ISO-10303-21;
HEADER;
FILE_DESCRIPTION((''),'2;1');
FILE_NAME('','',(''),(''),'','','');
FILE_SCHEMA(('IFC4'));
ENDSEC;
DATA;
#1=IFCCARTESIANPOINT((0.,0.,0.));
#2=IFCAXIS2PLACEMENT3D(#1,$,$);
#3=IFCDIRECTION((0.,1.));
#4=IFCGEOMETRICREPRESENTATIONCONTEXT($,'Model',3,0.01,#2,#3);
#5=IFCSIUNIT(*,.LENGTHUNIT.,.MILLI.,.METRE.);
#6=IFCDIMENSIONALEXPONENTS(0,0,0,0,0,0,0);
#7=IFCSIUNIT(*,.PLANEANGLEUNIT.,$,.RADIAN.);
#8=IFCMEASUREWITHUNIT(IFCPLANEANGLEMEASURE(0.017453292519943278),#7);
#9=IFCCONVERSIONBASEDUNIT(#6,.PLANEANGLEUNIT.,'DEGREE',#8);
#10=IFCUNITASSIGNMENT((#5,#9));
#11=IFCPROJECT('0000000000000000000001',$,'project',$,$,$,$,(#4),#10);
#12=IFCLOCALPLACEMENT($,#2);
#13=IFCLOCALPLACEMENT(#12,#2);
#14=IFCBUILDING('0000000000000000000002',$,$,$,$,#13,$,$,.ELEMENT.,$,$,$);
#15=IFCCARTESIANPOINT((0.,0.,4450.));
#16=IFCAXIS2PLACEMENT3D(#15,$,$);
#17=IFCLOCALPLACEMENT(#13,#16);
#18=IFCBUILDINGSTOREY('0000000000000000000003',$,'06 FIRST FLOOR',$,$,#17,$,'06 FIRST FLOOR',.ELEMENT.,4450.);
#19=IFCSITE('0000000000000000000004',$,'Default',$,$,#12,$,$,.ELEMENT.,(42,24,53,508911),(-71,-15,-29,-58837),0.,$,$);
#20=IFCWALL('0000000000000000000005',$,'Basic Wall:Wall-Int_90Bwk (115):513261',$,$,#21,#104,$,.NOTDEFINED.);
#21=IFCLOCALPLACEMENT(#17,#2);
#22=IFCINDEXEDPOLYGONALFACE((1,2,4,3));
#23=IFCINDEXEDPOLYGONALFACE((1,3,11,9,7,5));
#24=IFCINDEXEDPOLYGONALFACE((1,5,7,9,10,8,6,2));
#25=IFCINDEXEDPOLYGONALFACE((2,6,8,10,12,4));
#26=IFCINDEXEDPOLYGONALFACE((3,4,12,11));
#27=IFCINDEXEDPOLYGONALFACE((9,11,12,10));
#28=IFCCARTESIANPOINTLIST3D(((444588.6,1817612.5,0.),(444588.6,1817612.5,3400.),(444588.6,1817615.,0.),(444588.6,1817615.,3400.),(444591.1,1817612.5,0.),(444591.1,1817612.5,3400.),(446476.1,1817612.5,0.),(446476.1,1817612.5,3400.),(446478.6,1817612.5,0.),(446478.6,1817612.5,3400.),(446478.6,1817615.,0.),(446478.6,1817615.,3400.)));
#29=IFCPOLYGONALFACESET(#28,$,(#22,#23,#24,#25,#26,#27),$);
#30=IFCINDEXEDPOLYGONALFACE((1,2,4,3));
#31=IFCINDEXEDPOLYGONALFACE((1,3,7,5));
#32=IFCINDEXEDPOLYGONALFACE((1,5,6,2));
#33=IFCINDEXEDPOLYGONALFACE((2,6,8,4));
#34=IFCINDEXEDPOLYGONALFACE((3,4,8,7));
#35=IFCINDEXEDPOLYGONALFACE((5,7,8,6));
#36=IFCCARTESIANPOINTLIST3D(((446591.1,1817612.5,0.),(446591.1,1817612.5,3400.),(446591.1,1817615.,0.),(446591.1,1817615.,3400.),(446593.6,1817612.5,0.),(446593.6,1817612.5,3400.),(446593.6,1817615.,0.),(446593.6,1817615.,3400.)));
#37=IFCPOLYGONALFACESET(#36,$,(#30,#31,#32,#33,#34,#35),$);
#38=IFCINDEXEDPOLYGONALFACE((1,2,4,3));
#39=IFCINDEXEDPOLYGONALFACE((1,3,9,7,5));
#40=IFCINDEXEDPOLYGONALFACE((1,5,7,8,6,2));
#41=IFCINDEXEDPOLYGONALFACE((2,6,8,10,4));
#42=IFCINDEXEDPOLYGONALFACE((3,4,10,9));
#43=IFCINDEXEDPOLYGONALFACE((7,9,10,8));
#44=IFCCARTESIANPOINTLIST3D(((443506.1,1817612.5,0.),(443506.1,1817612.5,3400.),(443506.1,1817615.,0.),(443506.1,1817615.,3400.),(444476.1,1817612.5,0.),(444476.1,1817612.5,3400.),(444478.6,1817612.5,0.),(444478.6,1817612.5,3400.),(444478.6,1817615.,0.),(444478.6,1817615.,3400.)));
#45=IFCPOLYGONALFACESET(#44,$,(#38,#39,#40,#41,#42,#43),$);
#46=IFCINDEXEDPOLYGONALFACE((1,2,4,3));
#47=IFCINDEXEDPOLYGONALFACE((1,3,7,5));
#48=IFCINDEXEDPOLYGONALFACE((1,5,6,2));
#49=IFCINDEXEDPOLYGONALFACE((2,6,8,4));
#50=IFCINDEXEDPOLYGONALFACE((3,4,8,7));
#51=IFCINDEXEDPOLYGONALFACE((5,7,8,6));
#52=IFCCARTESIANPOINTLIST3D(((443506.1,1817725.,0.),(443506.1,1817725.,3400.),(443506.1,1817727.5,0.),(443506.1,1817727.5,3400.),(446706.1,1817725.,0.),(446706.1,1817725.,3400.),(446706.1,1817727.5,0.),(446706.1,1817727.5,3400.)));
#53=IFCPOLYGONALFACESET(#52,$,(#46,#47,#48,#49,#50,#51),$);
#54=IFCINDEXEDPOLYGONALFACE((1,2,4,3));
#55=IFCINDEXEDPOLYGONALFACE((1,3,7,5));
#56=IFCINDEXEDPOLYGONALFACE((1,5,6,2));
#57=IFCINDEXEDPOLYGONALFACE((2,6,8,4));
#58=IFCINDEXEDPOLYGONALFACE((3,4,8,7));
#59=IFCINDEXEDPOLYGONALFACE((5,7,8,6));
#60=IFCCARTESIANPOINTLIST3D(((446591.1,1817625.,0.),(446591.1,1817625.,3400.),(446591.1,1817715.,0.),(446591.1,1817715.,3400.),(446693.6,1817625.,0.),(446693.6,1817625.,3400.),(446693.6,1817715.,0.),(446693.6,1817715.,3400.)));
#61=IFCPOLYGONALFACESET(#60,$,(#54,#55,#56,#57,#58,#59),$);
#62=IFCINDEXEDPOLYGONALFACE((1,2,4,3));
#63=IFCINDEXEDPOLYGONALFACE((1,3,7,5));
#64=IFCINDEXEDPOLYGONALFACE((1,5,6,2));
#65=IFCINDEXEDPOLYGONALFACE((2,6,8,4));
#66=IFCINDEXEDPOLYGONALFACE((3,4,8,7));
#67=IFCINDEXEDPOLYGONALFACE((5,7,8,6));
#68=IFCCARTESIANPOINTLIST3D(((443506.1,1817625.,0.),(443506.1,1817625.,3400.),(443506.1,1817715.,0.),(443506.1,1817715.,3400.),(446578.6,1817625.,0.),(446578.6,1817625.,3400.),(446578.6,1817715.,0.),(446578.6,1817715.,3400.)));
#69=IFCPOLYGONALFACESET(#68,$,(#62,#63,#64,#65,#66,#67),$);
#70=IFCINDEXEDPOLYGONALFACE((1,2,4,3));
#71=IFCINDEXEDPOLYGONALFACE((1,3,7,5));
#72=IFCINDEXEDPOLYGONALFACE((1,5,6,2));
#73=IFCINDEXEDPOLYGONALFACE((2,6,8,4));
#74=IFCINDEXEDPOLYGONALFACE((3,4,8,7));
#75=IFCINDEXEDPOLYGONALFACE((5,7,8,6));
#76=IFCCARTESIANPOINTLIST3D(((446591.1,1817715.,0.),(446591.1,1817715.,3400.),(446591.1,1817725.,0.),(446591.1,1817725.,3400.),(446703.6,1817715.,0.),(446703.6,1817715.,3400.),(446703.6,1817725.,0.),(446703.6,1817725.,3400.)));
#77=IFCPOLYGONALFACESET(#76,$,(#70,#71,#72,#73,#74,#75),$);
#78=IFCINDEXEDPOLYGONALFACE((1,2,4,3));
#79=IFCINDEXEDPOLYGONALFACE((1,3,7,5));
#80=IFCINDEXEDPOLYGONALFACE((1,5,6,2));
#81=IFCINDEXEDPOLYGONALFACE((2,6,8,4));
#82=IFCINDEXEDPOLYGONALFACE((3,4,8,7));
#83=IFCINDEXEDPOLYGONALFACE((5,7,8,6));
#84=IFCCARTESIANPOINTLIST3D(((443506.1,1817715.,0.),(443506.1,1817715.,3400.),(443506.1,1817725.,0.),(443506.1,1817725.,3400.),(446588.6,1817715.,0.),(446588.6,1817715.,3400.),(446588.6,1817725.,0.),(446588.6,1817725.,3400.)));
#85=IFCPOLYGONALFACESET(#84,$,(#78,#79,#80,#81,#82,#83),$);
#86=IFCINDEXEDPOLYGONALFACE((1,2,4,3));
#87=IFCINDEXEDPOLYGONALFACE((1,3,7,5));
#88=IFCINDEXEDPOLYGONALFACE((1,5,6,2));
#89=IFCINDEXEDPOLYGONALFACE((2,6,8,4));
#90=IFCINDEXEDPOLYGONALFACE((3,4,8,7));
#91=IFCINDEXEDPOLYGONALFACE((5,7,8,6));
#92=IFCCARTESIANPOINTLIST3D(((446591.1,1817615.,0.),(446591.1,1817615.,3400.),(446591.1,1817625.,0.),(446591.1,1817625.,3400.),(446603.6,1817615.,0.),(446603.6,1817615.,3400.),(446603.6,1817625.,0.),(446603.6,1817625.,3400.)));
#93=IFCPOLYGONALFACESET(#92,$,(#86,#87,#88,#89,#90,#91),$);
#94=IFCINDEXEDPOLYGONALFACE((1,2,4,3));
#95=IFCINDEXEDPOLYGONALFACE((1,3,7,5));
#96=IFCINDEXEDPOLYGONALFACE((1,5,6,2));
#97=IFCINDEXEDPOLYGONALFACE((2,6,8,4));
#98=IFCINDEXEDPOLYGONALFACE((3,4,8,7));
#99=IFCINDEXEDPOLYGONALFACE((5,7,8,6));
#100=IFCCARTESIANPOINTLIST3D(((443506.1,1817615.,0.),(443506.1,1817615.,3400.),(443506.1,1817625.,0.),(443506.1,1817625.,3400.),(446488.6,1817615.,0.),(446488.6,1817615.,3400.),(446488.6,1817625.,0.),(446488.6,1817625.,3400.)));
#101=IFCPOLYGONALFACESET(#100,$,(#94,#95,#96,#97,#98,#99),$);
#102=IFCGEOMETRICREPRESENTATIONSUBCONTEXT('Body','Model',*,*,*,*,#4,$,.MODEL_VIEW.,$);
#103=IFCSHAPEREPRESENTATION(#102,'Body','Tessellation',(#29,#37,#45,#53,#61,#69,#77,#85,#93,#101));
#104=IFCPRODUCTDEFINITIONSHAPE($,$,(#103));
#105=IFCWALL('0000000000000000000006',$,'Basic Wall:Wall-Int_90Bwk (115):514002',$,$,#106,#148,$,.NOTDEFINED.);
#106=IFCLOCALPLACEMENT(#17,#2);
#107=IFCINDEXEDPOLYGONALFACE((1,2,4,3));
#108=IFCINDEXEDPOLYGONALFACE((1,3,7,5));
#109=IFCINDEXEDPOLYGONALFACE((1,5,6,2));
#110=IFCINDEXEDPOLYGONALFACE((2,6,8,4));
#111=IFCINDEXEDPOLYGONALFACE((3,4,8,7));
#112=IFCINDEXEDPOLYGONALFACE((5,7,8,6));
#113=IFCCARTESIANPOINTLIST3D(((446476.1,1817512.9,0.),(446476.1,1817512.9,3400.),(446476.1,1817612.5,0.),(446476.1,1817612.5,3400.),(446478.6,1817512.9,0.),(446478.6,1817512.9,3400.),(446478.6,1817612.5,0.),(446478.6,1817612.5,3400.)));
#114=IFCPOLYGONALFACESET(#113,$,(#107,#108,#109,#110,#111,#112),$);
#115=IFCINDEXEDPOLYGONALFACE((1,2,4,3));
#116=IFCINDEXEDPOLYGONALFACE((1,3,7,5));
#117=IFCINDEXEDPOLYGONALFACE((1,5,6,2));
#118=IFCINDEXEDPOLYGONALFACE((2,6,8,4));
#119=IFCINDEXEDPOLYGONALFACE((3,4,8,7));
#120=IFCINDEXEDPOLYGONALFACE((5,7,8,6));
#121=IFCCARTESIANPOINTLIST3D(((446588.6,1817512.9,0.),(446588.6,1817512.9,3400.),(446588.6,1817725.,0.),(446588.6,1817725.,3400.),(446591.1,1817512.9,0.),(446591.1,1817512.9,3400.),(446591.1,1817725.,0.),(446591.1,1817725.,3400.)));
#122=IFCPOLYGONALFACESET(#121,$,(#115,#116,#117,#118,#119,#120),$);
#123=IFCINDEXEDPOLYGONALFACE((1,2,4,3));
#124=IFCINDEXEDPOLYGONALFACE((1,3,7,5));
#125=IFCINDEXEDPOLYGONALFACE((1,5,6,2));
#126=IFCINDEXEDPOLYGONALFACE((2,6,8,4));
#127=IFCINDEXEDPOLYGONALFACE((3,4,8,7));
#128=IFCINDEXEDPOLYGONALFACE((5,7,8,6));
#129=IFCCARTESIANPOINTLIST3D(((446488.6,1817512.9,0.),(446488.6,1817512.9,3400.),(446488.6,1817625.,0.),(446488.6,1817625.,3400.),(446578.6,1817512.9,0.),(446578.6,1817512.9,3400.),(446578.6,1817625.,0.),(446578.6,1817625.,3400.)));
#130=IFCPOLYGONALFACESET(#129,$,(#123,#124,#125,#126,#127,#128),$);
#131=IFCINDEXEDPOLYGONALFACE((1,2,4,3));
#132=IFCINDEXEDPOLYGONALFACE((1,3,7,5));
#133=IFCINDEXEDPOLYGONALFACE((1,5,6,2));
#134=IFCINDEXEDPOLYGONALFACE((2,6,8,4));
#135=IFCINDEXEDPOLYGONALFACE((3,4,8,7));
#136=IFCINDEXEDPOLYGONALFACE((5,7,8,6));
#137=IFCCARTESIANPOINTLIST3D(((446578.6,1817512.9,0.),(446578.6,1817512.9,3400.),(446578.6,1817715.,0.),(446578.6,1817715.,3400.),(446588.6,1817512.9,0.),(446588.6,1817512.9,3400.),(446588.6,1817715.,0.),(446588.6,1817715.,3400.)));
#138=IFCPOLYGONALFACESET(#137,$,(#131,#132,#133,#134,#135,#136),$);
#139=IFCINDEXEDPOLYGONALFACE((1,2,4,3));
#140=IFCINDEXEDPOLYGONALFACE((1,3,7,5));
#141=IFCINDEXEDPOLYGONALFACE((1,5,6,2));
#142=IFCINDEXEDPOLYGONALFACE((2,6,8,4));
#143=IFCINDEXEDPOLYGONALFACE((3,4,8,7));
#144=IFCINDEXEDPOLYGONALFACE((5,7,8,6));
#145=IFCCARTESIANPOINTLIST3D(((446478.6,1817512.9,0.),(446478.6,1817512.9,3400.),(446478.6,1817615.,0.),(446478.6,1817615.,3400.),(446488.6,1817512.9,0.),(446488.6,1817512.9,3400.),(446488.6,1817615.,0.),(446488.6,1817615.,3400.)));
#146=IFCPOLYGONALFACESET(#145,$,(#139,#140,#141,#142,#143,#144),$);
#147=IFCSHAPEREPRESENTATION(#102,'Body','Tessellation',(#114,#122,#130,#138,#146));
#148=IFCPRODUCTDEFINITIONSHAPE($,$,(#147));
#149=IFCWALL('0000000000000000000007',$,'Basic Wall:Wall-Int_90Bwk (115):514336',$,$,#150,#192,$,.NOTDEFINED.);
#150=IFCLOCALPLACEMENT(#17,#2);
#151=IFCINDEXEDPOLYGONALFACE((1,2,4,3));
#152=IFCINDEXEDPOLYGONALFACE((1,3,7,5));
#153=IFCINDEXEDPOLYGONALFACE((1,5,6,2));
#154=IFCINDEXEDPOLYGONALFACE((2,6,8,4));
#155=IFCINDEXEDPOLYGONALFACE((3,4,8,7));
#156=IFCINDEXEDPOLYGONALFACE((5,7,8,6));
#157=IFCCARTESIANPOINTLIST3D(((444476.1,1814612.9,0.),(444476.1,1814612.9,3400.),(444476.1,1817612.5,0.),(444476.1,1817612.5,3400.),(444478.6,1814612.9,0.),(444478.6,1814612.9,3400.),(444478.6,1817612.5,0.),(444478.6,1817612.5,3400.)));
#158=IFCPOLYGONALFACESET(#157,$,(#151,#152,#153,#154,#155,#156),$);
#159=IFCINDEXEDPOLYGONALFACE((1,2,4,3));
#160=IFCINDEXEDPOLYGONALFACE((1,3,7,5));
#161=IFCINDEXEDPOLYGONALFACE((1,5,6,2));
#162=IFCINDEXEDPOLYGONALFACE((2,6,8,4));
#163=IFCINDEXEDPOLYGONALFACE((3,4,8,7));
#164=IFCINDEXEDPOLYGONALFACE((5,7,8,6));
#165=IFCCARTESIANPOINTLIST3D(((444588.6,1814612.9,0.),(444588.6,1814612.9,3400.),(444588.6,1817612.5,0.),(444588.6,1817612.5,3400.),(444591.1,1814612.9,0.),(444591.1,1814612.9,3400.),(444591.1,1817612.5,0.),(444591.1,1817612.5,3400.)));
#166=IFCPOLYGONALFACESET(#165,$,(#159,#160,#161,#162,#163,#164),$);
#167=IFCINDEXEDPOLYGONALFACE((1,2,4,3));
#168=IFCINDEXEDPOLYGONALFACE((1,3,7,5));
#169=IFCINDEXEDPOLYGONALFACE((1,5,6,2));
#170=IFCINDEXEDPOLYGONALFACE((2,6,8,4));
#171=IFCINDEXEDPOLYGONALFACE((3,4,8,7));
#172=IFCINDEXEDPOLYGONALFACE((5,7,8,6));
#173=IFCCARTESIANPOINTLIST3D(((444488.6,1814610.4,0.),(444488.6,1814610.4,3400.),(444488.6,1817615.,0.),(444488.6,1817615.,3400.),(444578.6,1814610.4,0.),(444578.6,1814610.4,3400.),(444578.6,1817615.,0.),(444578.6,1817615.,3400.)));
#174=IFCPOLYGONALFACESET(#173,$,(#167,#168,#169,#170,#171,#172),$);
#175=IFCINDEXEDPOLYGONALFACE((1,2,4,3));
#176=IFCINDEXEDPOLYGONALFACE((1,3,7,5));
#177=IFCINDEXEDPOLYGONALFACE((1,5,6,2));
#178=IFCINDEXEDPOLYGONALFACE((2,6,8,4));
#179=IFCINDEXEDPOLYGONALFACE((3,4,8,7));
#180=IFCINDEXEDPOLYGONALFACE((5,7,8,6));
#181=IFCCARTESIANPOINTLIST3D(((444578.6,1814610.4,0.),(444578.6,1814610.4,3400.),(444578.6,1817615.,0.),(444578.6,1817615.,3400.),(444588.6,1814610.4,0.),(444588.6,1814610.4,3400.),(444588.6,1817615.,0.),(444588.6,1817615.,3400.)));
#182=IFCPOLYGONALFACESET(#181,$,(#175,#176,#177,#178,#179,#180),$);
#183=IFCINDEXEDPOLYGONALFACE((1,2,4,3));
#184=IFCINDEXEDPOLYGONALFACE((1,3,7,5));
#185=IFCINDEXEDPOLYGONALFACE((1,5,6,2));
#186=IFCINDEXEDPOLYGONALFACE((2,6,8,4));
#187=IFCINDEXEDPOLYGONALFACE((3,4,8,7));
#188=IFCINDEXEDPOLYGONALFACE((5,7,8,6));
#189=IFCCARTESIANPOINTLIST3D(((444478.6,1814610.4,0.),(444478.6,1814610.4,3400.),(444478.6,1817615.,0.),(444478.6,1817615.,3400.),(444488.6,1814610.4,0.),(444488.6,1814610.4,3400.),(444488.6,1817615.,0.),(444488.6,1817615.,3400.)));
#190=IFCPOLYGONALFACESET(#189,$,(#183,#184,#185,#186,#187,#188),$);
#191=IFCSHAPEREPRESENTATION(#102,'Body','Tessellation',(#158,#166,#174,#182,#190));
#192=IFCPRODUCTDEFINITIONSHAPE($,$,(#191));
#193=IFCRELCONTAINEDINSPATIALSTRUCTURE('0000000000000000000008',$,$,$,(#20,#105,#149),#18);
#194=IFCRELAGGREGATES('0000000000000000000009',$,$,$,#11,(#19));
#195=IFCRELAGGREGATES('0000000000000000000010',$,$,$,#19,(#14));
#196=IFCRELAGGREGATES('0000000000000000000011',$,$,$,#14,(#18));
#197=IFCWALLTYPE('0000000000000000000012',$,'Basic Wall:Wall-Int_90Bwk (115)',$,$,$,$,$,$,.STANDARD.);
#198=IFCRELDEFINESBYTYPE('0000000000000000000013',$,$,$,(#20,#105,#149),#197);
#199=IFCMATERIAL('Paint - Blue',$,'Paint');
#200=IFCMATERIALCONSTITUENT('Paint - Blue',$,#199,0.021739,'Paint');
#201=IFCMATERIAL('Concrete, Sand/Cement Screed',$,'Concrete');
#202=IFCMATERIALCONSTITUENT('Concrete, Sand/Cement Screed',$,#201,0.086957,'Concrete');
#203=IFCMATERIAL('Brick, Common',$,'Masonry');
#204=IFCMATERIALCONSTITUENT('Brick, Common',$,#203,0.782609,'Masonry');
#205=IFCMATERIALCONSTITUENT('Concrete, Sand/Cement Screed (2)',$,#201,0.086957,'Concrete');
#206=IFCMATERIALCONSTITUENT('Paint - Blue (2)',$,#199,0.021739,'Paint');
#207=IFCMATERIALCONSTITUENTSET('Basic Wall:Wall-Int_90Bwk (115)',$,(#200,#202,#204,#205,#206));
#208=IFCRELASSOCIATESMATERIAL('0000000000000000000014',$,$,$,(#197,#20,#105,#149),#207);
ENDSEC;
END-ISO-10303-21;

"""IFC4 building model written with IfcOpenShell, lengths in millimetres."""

from ifc_helpers import new_model, entity, si_unit, converted_unit, direction, frame, origin, place, context, subcontext, project, spatial, indexed_curve, outline, extrude, material, constituent, constituent_set, type_object, element, save


model = new_model("IFC4")

# Units and contexts
model_context = context("Model", 3, precision=0.01, world=origin(), true_north=direction((0.0, 1.0)))
body_context = subcontext(model_context, "Body", "Model", "MODEL_VIEW")
ifc_project = project(units=[si_unit("LENGTHUNIT", "METRE", prefix="MILLI"), converted_unit("PLANEANGLEUNIT", "DEGREE", entity("IfcPlaneAngleMeasure", 0.017453292519943278), si_unit("PLANEANGLEUNIT", "RADIAN"), dimensions=[0, 0, 0, 0, 0, 0, 0])], contexts=[model_context])

# Site, building, storey
site_placement = place(None, origin())
site = spatial("IfcSite", under=ifc_project, at=site_placement, Name="Default", CompositionType="ELEMENT", RefLatitude=(42, 24, 53, 508911), RefLongitude=(-71, -15, -29, -58837), RefElevation=0.0)
building_placement = place(site_placement, origin())
building = spatial("IfcBuilding", under=site, at=building_placement, CompositionType="ELEMENT")
storey_placement = place(building_placement, frame((0.0, 0.0, 4450.0)))
storey = spatial("IfcBuildingStorey", under=building, at=storey_placement, Name="06 FIRST FLOOR", LongName="06 FIRST FLOOR", CompositionType="ELEMENT", Elevation=4450.0)

# Shared definitions
ifc_material_1 = material(Name="Paint - Blue", Category="Paint")
ifc_constituent_1 = constituent(ifc_material_1, Name="Paint - Blue", Category="Paint", fraction=0.021739)
ifc_material_2 = material(Name="Concrete, Sand/Cement Screed", Category="Concrete")
ifc_constituent_2 = constituent(ifc_material_2, Name="Concrete, Sand/Cement Screed", Category="Concrete", fraction=0.086957)
ifc_material_3 = material(Name="Brick, Common", Category="Masonry")
ifc_constituent_3 = constituent(ifc_material_3, Name="Brick, Common", Category="Masonry", fraction=0.782609)
ifc_constituent_4 = constituent(ifc_material_2, Name="Concrete, Sand/Cement Screed (2)", Category="Concrete", fraction=0.086957)
ifc_constituent_5 = constituent(ifc_material_1, Name="Paint - Blue (2)", Category="Paint", fraction=0.021739)
ifc_constituent_set_1 = constituent_set(constituents=[ifc_constituent_1, ifc_constituent_2, ifc_constituent_3, ifc_constituent_4, ifc_constituent_5], Name="Basic Wall:Wall-Int_90Bwk (115)")
wall_type_1 = type_object("IfcWallType", Name="Basic Wall:Wall-Int_90Bwk (115)", PredefinedType="STANDARD", material=ifc_constituent_set_1)

# Wall
wall_1_placement = place(storey_placement, frame((443506.1, 1817670.0, 0.0)))
element("IfcWall", 1, at=wall_1_placement, inside=storey, type_object=wall_type_1, material=ifc_constituent_set_1, Name="Basic Wall:Wall-Int_90Bwk (115):513261", PredefinedType="NOTDEFINED", context=body_context, shape_type="SweptSolid", body=[
    extrude(outline(indexed_curve([(942.5, -0.8), (945.0, -0.8), (945.0, 1.7), (-945.0, 1.7), (-945.0, -0.8), (-942.5, -0.8), (942.5, -0.8)], self_intersect=False)), frame((2027.5, -56.7, 0.0)), (0.0, 0.0, 1.0), 3400.0),
    extrude(outline(indexed_curve([(-1.3, -1.2), (1.2, -1.2), (1.2, 1.2), (-1.3, 1.2), (-1.3, -1.2)], self_intersect=False)), frame((3086.2, -56.2, 0.0), z_axis=(0.0, 0.0, 1.0), x_axis=(0.0, 1.0, 0.0)), (0.0, 0.0, 1.0), 3400.0),
    extrude(outline(indexed_curve([(387.0, -1.0), (389.5, -1.0), (389.5, 1.5), (-583.0, 1.5), (-583.0, -1.0), (387.0, -1.0)], self_intersect=False)), frame((583.0, -56.5, 0.0)), (0.0, 0.0, 1.0), 3400.0),
    extrude(outline(indexed_curve([(-1.3, -1600.0), (1.3, -1600.0), (1.3, 1600.0), (-1.3, 1600.0), (-1.3, -1600.0)], self_intersect=False)), frame((1600.0, 56.3, 0.0), z_axis=(0.0, 0.0, 1.0), x_axis=(0.0, -1.0, 0.0)), (0.0, 0.0, 1.0), 3400.0),
    extrude(outline(indexed_curve([(-51.3, -45.0), (51.2, -45.0), (51.2, 45.0), (-51.3, 45.0), (-51.3, -45.0)], self_intersect=False)), frame((3136.2, 0.0, 0.0), z_axis=(0.0, 0.0, 1.0), x_axis=(-1.0, 0.0, 0.0)), (0.0, 0.0, 1.0), 3400.0),
    extrude(outline(indexed_curve([(-1536.2, -45.0), (1536.2, -45.0), (1536.2, 45.0), (-1536.2, 45.0), (-1536.2, -45.0)], self_intersect=False)), frame((1536.2, 0.0, 0.0)), (0.0, 0.0, 1.0), 3400.0),
    extrude(outline(indexed_curve([(-56.2, -5.0), (56.3, -5.0), (56.3, 5.0), (-56.2, 5.0), (-56.2, -5.0)], self_intersect=False)), frame((3141.2, 50.0, 0.0), z_axis=(0.0, 0.0, 1.0), x_axis=(-1.0, 0.0, 0.0)), (0.0, 0.0, 1.0), 3400.0),
    extrude(outline(indexed_curve([(-1541.2, -5.0), (1541.2, -5.0), (1541.2, 5.0), (-1541.2, 5.0), (-1541.2, -5.0)], self_intersect=False)), frame((1541.2, 50.0, 0.0)), (0.0, 0.0, 1.0), 3400.0),
    extrude(outline(indexed_curve([(-6.3, -5.0), (6.3, -5.0), (6.3, 5.0), (-6.3, 5.0), (-6.3, -5.0)], self_intersect=False)), frame((3091.2, -50.0, 0.0), z_axis=(0.0, 0.0, 1.0), x_axis=(-1.0, 0.0, 0.0)), (0.0, 0.0, 1.0), 3400.0),
    extrude(outline(indexed_curve([(-1491.2, -5.0), (1491.2, -5.0), (1491.2, 5.0), (-1491.2, 5.0), (-1491.2, -5.0)], self_intersect=False)), frame((1491.2, -50.0, 0.0)), (0.0, 0.0, 1.0), 3400.0),
])

# Walls
wall_2_placement = place(storey_placement, frame((446533.6, 1817612.5, 0.0), z_axis=(0.0, 0.0, 1.0), x_axis=(0.0, -1.0, 0.0)))
element("IfcWall", 2, at=wall_2_placement, inside=storey, type_object=wall_type_1, material=ifc_constituent_set_1, Name="Basic Wall:Wall-Int_90Bwk (115):514002", PredefinedType="NOTDEFINED", context=body_context, shape_type="SweptSolid", body=[
    extrude(outline(indexed_curve([(-1.3, -49.8), (1.2, -49.8), (1.2, 49.8), (-1.3, 49.8), (-1.3, -49.8)], self_intersect=False)), frame((49.8, -56.2, 0.0), z_axis=(0.0, 0.0, 1.0), x_axis=(0.0, 1.0, 0.0)), (0.0, 0.0, 1.0), 3400.0),
    extrude(outline(indexed_curve([(-1.3, -106.1), (1.2, -106.1), (1.2, 106.1), (-1.3, 106.1), (-1.3, -106.1)], self_intersect=False)), frame((-6.4, 56.2, 0.0), z_axis=(0.0, 0.0, 1.0), x_axis=(0.0, -1.0, 0.0)), (0.0, 0.0, 1.0), 3400.0),
    extrude(outline(indexed_curve([(-56.1, -45.0), (56.1, -45.0), (56.1, 45.0), (-56.1, 45.0), (-56.1, -45.0)], self_intersect=False)), frame((43.6, 0.0, 0.0)), (0.0, 0.0, 1.0), 3400.0),
    extrude(outline(indexed_curve([(-101.1, -5.0), (101.1, -5.0), (101.1, 5.0), (-101.1, 5.0), (-101.1, -5.0)], self_intersect=False)), frame((-1.4, 50.0, 0.0)), (0.0, 0.0, 1.0), 3400.0),
    extrude(outline(indexed_curve([(-51.1, -5.0), (51.1, -5.0), (51.1, 5.0), (-51.1, 5.0), (-51.1, -5.0)], self_intersect=False)), frame((48.6, -50.0, 0.0)), (0.0, 0.0, 1.0), 3400.0),
])
wall_3_placement = place(storey_placement, frame((444533.6, 1817612.5, 0.0), z_axis=(0.0, 0.0, 1.0), x_axis=(0.0, -1.0, 0.0)))
element("IfcWall", 3, at=wall_3_placement, inside=storey, type_object=wall_type_1, material=ifc_constituent_set_1, Name="Basic Wall:Wall-Int_90Bwk (115):514336", PredefinedType="NOTDEFINED", context=body_context, shape_type="SweptSolid", body=[
    extrude(outline(indexed_curve([(-1.2, -1499.8), (1.3, -1499.8), (1.3, 1499.8), (-1.2, 1499.8), (-1.2, -1499.8)], self_intersect=False)), frame((1499.8, -56.3, 0.0), z_axis=(0.0, 0.0, 1.0), x_axis=(0.0, 1.0, 0.0)), (0.0, 0.0, 1.0), 3400.0),
    extrude(outline(indexed_curve([(-1.3, -1499.8), (1.2, -1499.8), (1.2, 1499.8), (-1.3, 1499.8), (-1.3, -1499.8)], self_intersect=False)), frame((1499.8, 56.2, 0.0), z_axis=(0.0, 0.0, 1.0), x_axis=(0.0, -1.0, 0.0)), (0.0, 0.0, 1.0), 3400.0),
    extrude(outline(indexed_curve([(-1502.3, -45.0), (1502.3, -45.0), (1502.3, 45.0), (-1502.3, 45.0), (-1502.3, -45.0)], self_intersect=False)), frame((1499.8, 0.0, 0.0)), (0.0, 0.0, 1.0), 3400.0),
    extrude(outline(indexed_curve([(-1502.3, -5.0), (1502.3, -5.0), (1502.3, 5.0), (-1502.3, 5.0), (-1502.3, -5.0)], self_intersect=False)), frame((1499.8, 50.0, 0.0)), (0.0, 0.0, 1.0), 3400.0),
    extrude(outline(indexed_curve([(-1502.3, -5.0), (1502.3, -5.0), (1502.3, 5.0), (-1502.3, 5.0), (-1502.3, -5.0)], self_intersect=False)), frame((1499.8, -50.0, 0.0)), (0.0, 0.0, 1.0), 3400.0),
])

save(model, "model.ifc")
